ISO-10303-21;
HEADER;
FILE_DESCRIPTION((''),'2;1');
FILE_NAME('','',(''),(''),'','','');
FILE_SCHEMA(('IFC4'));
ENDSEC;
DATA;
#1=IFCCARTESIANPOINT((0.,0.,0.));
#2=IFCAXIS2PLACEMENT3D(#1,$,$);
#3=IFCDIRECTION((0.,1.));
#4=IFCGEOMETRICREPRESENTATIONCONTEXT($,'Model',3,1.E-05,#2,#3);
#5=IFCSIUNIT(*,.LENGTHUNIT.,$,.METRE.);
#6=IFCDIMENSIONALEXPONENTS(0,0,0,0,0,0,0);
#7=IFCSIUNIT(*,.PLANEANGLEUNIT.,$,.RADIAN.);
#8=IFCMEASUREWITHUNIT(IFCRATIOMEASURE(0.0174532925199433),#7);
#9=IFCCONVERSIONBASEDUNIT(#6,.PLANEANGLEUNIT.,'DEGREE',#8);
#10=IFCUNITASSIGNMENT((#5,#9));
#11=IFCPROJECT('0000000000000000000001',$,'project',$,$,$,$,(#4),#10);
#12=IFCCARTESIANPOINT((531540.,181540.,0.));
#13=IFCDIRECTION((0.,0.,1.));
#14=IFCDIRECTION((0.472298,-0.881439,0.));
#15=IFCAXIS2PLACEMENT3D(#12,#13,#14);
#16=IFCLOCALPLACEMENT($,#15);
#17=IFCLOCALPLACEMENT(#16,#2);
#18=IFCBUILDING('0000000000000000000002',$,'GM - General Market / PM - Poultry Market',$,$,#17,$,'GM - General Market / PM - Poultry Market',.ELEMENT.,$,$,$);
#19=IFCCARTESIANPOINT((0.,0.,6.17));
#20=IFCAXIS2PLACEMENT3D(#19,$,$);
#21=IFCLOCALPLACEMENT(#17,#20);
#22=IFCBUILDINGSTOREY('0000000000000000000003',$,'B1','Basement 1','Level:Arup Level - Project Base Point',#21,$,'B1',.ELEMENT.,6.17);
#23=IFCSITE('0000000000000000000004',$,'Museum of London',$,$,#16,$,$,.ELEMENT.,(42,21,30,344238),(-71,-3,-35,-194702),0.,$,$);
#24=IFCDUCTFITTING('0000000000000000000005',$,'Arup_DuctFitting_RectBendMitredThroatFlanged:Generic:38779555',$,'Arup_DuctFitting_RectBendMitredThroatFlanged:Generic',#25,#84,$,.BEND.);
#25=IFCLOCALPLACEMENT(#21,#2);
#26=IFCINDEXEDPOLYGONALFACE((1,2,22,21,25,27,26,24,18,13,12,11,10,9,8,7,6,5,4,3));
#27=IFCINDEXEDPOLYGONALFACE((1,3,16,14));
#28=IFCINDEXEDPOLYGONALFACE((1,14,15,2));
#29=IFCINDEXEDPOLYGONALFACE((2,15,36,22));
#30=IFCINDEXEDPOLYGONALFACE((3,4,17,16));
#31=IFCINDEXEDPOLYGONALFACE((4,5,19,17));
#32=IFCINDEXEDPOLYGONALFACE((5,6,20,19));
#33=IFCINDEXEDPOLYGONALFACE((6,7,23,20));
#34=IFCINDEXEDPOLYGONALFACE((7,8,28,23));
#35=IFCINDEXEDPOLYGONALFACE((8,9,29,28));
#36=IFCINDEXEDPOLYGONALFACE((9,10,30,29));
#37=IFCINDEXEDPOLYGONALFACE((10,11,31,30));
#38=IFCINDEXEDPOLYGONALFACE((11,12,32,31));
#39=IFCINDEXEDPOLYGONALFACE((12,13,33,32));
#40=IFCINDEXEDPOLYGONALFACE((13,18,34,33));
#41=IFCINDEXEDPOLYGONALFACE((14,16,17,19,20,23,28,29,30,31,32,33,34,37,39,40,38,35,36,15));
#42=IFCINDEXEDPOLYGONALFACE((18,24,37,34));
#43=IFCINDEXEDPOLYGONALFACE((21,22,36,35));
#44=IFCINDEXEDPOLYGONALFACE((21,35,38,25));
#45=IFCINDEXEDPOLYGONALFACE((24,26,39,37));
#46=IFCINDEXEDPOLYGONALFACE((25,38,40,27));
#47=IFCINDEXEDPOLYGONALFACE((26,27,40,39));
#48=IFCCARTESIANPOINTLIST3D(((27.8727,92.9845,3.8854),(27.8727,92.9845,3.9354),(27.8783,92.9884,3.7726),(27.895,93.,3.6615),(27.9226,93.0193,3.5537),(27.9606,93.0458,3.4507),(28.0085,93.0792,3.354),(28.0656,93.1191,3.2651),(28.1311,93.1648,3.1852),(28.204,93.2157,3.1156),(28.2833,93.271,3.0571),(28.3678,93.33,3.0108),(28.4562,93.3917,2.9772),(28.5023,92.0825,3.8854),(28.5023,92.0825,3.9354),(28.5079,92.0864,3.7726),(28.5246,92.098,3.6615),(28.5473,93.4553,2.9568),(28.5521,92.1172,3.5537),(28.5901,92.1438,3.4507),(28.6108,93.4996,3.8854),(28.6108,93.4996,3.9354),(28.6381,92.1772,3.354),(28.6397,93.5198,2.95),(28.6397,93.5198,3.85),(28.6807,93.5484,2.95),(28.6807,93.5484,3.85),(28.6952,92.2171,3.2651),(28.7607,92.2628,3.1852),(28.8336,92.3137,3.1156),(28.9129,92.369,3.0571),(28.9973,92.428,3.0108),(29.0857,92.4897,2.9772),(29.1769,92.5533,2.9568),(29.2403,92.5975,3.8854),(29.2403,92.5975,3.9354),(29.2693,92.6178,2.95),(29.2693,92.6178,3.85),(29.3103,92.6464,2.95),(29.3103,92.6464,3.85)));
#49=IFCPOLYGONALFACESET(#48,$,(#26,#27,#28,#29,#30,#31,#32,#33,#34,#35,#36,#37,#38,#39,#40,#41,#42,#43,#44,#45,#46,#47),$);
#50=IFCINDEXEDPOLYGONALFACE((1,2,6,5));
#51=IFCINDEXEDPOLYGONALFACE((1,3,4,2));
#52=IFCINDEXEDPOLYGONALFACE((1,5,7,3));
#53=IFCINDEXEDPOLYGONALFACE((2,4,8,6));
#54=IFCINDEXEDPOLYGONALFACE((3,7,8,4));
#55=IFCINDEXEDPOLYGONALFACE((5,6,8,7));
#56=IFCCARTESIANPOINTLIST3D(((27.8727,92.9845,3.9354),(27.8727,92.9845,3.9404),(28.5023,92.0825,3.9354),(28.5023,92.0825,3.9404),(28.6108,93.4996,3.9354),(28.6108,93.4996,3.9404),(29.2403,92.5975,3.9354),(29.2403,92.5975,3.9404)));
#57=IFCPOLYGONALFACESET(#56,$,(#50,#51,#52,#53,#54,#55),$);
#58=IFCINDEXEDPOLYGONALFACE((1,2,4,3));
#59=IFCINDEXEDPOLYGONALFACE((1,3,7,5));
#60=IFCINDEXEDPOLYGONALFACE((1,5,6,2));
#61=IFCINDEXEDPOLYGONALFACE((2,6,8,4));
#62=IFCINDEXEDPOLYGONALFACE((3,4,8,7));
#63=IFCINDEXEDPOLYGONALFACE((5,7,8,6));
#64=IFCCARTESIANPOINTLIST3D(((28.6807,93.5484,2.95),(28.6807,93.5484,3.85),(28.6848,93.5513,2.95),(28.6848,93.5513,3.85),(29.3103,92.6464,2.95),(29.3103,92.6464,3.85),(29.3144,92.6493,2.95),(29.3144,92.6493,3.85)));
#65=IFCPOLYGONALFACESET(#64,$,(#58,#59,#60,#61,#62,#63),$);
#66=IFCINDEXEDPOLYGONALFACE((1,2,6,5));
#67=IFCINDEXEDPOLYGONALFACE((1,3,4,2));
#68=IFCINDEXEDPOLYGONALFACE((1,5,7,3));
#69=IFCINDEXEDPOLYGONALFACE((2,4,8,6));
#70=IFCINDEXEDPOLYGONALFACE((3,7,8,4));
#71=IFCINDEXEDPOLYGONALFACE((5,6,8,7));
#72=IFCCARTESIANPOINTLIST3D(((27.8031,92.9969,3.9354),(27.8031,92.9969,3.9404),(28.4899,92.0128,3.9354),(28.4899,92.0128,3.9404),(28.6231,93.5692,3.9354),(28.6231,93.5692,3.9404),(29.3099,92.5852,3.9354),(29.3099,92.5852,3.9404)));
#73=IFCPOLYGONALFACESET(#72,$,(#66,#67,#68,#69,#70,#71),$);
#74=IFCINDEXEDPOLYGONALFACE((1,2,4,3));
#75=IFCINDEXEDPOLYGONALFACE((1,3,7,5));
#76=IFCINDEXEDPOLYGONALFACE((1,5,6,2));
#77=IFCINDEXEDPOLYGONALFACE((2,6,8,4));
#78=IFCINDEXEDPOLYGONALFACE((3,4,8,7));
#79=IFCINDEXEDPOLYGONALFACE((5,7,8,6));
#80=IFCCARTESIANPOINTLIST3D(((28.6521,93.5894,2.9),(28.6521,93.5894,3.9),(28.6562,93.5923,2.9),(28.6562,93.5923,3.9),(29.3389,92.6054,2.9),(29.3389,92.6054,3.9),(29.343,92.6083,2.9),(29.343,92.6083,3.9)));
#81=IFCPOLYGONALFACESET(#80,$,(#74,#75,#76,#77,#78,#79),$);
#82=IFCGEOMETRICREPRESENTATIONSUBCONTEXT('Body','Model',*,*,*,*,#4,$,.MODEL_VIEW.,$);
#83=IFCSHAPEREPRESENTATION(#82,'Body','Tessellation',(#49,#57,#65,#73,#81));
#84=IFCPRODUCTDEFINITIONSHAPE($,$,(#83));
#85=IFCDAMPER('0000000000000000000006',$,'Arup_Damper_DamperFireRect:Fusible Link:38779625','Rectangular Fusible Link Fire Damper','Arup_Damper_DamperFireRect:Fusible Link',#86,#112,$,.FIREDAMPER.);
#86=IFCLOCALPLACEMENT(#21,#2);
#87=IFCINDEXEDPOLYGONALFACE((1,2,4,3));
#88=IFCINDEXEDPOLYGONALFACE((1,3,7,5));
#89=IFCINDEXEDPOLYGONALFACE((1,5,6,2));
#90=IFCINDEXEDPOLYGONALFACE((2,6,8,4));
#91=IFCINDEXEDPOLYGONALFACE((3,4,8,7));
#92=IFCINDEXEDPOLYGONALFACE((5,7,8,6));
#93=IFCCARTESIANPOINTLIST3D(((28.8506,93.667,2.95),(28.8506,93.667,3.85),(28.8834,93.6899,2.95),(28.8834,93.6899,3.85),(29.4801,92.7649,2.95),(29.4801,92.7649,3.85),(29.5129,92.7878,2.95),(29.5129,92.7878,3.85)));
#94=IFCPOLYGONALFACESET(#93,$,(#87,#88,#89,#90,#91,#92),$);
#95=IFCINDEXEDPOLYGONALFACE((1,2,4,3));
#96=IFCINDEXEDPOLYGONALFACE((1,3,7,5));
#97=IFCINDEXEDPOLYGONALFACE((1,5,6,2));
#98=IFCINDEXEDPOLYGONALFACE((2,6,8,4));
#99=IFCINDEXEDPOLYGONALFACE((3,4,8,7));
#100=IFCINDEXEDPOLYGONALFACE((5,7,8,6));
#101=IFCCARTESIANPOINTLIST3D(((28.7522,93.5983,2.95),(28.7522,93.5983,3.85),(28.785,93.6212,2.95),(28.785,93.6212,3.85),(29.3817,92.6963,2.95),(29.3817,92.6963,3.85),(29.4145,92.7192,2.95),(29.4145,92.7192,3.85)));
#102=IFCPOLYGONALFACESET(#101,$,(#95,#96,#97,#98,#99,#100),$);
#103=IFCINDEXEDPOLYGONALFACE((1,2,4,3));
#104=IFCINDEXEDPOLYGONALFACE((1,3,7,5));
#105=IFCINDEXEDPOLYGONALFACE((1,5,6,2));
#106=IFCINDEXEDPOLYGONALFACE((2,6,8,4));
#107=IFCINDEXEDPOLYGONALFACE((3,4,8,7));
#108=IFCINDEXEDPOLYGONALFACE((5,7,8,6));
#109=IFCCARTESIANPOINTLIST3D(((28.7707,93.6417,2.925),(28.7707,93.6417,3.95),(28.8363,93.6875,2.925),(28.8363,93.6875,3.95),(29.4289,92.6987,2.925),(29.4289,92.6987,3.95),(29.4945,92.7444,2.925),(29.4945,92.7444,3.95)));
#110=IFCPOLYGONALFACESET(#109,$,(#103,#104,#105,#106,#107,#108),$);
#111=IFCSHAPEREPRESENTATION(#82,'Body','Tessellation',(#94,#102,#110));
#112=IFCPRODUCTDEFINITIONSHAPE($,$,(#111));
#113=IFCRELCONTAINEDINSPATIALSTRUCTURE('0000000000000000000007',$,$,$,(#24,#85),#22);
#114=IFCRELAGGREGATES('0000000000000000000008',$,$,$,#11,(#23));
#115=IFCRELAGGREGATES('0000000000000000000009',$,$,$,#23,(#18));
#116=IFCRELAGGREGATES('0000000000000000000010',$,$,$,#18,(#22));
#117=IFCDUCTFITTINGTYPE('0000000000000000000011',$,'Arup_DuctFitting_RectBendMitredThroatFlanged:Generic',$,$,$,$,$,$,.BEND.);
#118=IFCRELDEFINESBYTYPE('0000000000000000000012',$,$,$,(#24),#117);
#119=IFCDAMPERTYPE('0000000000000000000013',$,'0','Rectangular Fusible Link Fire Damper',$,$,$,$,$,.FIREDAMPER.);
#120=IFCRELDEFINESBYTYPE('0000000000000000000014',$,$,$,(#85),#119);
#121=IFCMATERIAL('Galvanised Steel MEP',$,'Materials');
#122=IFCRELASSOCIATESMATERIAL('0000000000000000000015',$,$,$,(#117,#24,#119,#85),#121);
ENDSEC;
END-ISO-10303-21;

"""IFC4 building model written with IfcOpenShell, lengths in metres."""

from ifc_helpers import new_model, entity, si_unit, converted_unit, direction, frame, frame_2d, origin, origin_2d_with_axis, place, context, subcontext, project, spatial, polyline, circle_curve, parameter, trimmed, segment, composite_curve, rectangle, outline, extrude, source, transform, mapped, material, type_object, type_shapes, element, save


model = new_model("IFC4")

# Units and contexts
model_context = context("Model", 3, precision=1e-05, world=origin(), true_north=direction((0.0, 1.0)))
body_context = subcontext(model_context, "Body", "Model", "MODEL_VIEW")
ifc_project = project(units=[si_unit("LENGTHUNIT", "METRE"), converted_unit("PLANEANGLEUNIT", "DEGREE", entity("IfcRatioMeasure", 0.0174532925199433), si_unit("PLANEANGLEUNIT", "RADIAN"), dimensions=[0, 0, 0, 0, 0, 0, 0])], contexts=[model_context])

# Site, building, storey
site_placement = place(None, frame((531540.0, 181540.0, 0.0), z_axis=(0.0, 0.0, 1.0), x_axis=(0.472298, -0.881439, 0.0)))
site = spatial("IfcSite", under=ifc_project, at=site_placement, Name="Museum of London", CompositionType="ELEMENT", RefLatitude=(42, 21, 30, 344238), RefLongitude=(-71, -3, -35, -194702), RefElevation=0.0)
building_placement = place(site_placement, origin())
building = spatial("IfcBuilding", under=site, at=building_placement, Name="GM - General Market / PM - Poultry Market", LongName="GM - General Market / PM - Poultry Market", CompositionType="ELEMENT")
storey_placement = place(building_placement, frame((0.0, 0.0, 6.17)))
storey = spatial("IfcBuildingStorey", under=building, at=storey_placement, Name="B1", Description="Basement 1", ObjectType="Level:Arup Level - Project Base Point", LongName="B1", CompositionType="ELEMENT", Elevation=6.17)

# Shared definitions
ifc_material_1 = material(Name="Galvanised Steel MEP", Category="Materials")

# Duct fitting
duct_fitting_type_1 = type_object("IfcDuctFittingType", Name="Arup_DuctFitting_RectBendMitredThroatFlanged:Generic", PredefinedType="BEND", material=ifc_material_1)
shared_shape_1 = source(origin(), body_context, "Body", "SweptSolid", [
    extrude(outline(composite_curve([segment(polyline([(0.2302, -0.1948), (0.2802, -0.1948)]), True, "CONTINUOUS"), segment(polyline([(0.2802, -0.1948), (0.2802, 0.7052)]), True, "CONTINUOUS"), segment(polyline([(0.2802, 0.7052), (0.2302, 0.7052)]), True, "CONTINUOUS"), segment(trimmed(circle_curve(frame_2d((0.2302, -0.2302), x_axis=(-1.0, 0.0)), 0.9354), [parameter(270.0)], [parameter(0.0)], True, "PARAMETER"), True, "CONTINUOUS"), segment(polyline([(-0.7052, -0.2302), (-0.7052, -0.2802)]), True, "CONTINUOUS"), segment(polyline([(-0.7052, -0.2802), (0.1948, -0.2802)]), True, "CONTINUOUS"), segment(polyline([(0.1948, -0.2802), (0.1948, -0.2302)]), True, "CONTINUOUS"), segment(polyline([(0.1948, -0.2302), (0.2302, -0.1948)]), True, "CONTINUOUS")], self_intersect=False)), frame((-0.2552, 0.2552, -0.55), z_axis=(0.0, 0.0, 1.0), x_axis=(-1.0, 0.0, 0.0)), (0.0, 0.0, 1.0), 1.1),
    extrude(rectangle(XDim=0.005, YDim=0.9, at=frame_2d((0.0, 0.0), x_axis=(1.0, 0.0))), frame((0.0, 0.5379, -0.55), z_axis=(0.0, 0.0, 1.0), x_axis=(0.0, 1.0, 0.0)), (0.0, 0.0, 1.0), 1.1),
    extrude(rectangle(XDim=0.005, YDim=0.9, at=origin_2d_with_axis()), frame((-0.5379, 0.0, -0.55), z_axis=(0.0, 0.0, 1.0), x_axis=(-1.0, 0.0, 0.0)), (0.0, 0.0, 1.0), 1.1),
    extrude(rectangle(XDim=0.005, YDim=1.0, at=frame_2d((0.0, 0.0), x_axis=(1.0, 0.0))), frame((0.0, 0.5379, -0.6), z_axis=(0.0, 0.0, 1.0), x_axis=(0.0, 1.0, 0.0)), (0.0, 0.0, 1.0), 1.2),
    extrude(rectangle(XDim=0.005, YDim=1.0, at=origin_2d_with_axis()), frame((-0.5379, 0.0, -0.6), z_axis=(0.0, 0.0, 1.0), x_axis=(-1.0, 0.0, 0.0)), (0.0, 0.0, 1.0), 1.2),
])
type_shapes(duct_fitting_type_1, [shared_shape_1])
duct_fitting_1_placement = place(storey_placement, frame((28.5565, 92.791, 3.4), z_axis=(-0.572325, 0.820027, 0.0), x_axis=(-0.820027, -0.572325, 0.0)))
element("IfcDuctFitting", 1, at=duct_fitting_1_placement, inside=storey, type_object=duct_fitting_type_1, material=ifc_material_1, Name="Arup_DuctFitting_RectBendMitredThroatFlanged:Generic:38779555", ObjectType="Arup_DuctFitting_RectBendMitredThroatFlanged:Generic", PredefinedType="BEND", context=body_context, shape_type="MappedRepresentation", body=[
    mapped(shared_shape_1, transform((0.0, 0.0, 0.0), scale=1.0)),
])

# Damper
damper_type = type_object("IfcDamperType", Name="0", Description="Rectangular Fusible Link Fire Damper", PredefinedType="FIREDAMPER", material=ifc_material_1)
shared_shape_2 = source(origin(), body_context, "Body", "SweptSolid", [
    extrude(rectangle(XDim=0.04, YDim=1.1, at=frame_2d((0.0, 0.0), x_axis=(1.0, 0.0))), frame((-0.06, 0.0, -0.45)), (0.0, 0.0, 1.0), 0.9),
    extrude(rectangle(XDim=0.04, YDim=1.1, at=frame_2d((0.0, 0.0), x_axis=(1.0, 0.0))), frame((0.06, 0.0, -0.45), z_axis=(0.0, 0.0, 1.0), x_axis=(-1.0, 0.0, 0.0)), (0.0, 0.0, 1.0), 0.9),
    extrude(rectangle(XDim=0.08, YDim=1.15, at=origin_2d_with_axis()), frame((0.0, 0.0, -0.475), z_axis=(0.0, 0.0, 1.0), x_axis=(-1.0, 0.0, 0.0)), (0.0, 0.0, 1.0), 1.025),
])
type_shapes(damper_type, [shared_shape_2])
damper_placement = place(storey_placement, frame((29.1326, 93.1931, 3.4), z_axis=(0.0, 0.0, 1.0), x_axis=(-0.820027, -0.572325, 0.0)))
element("IfcDamper", 2, at=damper_placement, inside=storey, type_object=damper_type, material=ifc_material_1, Name="Arup_Damper_DamperFireRect:Fusible Link:38779625", Description="Rectangular Fusible Link Fire Damper", ObjectType="Arup_Damper_DamperFireRect:Fusible Link", PredefinedType="FIREDAMPER", context=body_context, shape_type="MappedRepresentation", body=[
    mapped(shared_shape_2, transform((0.0, 0.0, 0.0), scale=1.0)),
])

save(model, "model.ifc")
